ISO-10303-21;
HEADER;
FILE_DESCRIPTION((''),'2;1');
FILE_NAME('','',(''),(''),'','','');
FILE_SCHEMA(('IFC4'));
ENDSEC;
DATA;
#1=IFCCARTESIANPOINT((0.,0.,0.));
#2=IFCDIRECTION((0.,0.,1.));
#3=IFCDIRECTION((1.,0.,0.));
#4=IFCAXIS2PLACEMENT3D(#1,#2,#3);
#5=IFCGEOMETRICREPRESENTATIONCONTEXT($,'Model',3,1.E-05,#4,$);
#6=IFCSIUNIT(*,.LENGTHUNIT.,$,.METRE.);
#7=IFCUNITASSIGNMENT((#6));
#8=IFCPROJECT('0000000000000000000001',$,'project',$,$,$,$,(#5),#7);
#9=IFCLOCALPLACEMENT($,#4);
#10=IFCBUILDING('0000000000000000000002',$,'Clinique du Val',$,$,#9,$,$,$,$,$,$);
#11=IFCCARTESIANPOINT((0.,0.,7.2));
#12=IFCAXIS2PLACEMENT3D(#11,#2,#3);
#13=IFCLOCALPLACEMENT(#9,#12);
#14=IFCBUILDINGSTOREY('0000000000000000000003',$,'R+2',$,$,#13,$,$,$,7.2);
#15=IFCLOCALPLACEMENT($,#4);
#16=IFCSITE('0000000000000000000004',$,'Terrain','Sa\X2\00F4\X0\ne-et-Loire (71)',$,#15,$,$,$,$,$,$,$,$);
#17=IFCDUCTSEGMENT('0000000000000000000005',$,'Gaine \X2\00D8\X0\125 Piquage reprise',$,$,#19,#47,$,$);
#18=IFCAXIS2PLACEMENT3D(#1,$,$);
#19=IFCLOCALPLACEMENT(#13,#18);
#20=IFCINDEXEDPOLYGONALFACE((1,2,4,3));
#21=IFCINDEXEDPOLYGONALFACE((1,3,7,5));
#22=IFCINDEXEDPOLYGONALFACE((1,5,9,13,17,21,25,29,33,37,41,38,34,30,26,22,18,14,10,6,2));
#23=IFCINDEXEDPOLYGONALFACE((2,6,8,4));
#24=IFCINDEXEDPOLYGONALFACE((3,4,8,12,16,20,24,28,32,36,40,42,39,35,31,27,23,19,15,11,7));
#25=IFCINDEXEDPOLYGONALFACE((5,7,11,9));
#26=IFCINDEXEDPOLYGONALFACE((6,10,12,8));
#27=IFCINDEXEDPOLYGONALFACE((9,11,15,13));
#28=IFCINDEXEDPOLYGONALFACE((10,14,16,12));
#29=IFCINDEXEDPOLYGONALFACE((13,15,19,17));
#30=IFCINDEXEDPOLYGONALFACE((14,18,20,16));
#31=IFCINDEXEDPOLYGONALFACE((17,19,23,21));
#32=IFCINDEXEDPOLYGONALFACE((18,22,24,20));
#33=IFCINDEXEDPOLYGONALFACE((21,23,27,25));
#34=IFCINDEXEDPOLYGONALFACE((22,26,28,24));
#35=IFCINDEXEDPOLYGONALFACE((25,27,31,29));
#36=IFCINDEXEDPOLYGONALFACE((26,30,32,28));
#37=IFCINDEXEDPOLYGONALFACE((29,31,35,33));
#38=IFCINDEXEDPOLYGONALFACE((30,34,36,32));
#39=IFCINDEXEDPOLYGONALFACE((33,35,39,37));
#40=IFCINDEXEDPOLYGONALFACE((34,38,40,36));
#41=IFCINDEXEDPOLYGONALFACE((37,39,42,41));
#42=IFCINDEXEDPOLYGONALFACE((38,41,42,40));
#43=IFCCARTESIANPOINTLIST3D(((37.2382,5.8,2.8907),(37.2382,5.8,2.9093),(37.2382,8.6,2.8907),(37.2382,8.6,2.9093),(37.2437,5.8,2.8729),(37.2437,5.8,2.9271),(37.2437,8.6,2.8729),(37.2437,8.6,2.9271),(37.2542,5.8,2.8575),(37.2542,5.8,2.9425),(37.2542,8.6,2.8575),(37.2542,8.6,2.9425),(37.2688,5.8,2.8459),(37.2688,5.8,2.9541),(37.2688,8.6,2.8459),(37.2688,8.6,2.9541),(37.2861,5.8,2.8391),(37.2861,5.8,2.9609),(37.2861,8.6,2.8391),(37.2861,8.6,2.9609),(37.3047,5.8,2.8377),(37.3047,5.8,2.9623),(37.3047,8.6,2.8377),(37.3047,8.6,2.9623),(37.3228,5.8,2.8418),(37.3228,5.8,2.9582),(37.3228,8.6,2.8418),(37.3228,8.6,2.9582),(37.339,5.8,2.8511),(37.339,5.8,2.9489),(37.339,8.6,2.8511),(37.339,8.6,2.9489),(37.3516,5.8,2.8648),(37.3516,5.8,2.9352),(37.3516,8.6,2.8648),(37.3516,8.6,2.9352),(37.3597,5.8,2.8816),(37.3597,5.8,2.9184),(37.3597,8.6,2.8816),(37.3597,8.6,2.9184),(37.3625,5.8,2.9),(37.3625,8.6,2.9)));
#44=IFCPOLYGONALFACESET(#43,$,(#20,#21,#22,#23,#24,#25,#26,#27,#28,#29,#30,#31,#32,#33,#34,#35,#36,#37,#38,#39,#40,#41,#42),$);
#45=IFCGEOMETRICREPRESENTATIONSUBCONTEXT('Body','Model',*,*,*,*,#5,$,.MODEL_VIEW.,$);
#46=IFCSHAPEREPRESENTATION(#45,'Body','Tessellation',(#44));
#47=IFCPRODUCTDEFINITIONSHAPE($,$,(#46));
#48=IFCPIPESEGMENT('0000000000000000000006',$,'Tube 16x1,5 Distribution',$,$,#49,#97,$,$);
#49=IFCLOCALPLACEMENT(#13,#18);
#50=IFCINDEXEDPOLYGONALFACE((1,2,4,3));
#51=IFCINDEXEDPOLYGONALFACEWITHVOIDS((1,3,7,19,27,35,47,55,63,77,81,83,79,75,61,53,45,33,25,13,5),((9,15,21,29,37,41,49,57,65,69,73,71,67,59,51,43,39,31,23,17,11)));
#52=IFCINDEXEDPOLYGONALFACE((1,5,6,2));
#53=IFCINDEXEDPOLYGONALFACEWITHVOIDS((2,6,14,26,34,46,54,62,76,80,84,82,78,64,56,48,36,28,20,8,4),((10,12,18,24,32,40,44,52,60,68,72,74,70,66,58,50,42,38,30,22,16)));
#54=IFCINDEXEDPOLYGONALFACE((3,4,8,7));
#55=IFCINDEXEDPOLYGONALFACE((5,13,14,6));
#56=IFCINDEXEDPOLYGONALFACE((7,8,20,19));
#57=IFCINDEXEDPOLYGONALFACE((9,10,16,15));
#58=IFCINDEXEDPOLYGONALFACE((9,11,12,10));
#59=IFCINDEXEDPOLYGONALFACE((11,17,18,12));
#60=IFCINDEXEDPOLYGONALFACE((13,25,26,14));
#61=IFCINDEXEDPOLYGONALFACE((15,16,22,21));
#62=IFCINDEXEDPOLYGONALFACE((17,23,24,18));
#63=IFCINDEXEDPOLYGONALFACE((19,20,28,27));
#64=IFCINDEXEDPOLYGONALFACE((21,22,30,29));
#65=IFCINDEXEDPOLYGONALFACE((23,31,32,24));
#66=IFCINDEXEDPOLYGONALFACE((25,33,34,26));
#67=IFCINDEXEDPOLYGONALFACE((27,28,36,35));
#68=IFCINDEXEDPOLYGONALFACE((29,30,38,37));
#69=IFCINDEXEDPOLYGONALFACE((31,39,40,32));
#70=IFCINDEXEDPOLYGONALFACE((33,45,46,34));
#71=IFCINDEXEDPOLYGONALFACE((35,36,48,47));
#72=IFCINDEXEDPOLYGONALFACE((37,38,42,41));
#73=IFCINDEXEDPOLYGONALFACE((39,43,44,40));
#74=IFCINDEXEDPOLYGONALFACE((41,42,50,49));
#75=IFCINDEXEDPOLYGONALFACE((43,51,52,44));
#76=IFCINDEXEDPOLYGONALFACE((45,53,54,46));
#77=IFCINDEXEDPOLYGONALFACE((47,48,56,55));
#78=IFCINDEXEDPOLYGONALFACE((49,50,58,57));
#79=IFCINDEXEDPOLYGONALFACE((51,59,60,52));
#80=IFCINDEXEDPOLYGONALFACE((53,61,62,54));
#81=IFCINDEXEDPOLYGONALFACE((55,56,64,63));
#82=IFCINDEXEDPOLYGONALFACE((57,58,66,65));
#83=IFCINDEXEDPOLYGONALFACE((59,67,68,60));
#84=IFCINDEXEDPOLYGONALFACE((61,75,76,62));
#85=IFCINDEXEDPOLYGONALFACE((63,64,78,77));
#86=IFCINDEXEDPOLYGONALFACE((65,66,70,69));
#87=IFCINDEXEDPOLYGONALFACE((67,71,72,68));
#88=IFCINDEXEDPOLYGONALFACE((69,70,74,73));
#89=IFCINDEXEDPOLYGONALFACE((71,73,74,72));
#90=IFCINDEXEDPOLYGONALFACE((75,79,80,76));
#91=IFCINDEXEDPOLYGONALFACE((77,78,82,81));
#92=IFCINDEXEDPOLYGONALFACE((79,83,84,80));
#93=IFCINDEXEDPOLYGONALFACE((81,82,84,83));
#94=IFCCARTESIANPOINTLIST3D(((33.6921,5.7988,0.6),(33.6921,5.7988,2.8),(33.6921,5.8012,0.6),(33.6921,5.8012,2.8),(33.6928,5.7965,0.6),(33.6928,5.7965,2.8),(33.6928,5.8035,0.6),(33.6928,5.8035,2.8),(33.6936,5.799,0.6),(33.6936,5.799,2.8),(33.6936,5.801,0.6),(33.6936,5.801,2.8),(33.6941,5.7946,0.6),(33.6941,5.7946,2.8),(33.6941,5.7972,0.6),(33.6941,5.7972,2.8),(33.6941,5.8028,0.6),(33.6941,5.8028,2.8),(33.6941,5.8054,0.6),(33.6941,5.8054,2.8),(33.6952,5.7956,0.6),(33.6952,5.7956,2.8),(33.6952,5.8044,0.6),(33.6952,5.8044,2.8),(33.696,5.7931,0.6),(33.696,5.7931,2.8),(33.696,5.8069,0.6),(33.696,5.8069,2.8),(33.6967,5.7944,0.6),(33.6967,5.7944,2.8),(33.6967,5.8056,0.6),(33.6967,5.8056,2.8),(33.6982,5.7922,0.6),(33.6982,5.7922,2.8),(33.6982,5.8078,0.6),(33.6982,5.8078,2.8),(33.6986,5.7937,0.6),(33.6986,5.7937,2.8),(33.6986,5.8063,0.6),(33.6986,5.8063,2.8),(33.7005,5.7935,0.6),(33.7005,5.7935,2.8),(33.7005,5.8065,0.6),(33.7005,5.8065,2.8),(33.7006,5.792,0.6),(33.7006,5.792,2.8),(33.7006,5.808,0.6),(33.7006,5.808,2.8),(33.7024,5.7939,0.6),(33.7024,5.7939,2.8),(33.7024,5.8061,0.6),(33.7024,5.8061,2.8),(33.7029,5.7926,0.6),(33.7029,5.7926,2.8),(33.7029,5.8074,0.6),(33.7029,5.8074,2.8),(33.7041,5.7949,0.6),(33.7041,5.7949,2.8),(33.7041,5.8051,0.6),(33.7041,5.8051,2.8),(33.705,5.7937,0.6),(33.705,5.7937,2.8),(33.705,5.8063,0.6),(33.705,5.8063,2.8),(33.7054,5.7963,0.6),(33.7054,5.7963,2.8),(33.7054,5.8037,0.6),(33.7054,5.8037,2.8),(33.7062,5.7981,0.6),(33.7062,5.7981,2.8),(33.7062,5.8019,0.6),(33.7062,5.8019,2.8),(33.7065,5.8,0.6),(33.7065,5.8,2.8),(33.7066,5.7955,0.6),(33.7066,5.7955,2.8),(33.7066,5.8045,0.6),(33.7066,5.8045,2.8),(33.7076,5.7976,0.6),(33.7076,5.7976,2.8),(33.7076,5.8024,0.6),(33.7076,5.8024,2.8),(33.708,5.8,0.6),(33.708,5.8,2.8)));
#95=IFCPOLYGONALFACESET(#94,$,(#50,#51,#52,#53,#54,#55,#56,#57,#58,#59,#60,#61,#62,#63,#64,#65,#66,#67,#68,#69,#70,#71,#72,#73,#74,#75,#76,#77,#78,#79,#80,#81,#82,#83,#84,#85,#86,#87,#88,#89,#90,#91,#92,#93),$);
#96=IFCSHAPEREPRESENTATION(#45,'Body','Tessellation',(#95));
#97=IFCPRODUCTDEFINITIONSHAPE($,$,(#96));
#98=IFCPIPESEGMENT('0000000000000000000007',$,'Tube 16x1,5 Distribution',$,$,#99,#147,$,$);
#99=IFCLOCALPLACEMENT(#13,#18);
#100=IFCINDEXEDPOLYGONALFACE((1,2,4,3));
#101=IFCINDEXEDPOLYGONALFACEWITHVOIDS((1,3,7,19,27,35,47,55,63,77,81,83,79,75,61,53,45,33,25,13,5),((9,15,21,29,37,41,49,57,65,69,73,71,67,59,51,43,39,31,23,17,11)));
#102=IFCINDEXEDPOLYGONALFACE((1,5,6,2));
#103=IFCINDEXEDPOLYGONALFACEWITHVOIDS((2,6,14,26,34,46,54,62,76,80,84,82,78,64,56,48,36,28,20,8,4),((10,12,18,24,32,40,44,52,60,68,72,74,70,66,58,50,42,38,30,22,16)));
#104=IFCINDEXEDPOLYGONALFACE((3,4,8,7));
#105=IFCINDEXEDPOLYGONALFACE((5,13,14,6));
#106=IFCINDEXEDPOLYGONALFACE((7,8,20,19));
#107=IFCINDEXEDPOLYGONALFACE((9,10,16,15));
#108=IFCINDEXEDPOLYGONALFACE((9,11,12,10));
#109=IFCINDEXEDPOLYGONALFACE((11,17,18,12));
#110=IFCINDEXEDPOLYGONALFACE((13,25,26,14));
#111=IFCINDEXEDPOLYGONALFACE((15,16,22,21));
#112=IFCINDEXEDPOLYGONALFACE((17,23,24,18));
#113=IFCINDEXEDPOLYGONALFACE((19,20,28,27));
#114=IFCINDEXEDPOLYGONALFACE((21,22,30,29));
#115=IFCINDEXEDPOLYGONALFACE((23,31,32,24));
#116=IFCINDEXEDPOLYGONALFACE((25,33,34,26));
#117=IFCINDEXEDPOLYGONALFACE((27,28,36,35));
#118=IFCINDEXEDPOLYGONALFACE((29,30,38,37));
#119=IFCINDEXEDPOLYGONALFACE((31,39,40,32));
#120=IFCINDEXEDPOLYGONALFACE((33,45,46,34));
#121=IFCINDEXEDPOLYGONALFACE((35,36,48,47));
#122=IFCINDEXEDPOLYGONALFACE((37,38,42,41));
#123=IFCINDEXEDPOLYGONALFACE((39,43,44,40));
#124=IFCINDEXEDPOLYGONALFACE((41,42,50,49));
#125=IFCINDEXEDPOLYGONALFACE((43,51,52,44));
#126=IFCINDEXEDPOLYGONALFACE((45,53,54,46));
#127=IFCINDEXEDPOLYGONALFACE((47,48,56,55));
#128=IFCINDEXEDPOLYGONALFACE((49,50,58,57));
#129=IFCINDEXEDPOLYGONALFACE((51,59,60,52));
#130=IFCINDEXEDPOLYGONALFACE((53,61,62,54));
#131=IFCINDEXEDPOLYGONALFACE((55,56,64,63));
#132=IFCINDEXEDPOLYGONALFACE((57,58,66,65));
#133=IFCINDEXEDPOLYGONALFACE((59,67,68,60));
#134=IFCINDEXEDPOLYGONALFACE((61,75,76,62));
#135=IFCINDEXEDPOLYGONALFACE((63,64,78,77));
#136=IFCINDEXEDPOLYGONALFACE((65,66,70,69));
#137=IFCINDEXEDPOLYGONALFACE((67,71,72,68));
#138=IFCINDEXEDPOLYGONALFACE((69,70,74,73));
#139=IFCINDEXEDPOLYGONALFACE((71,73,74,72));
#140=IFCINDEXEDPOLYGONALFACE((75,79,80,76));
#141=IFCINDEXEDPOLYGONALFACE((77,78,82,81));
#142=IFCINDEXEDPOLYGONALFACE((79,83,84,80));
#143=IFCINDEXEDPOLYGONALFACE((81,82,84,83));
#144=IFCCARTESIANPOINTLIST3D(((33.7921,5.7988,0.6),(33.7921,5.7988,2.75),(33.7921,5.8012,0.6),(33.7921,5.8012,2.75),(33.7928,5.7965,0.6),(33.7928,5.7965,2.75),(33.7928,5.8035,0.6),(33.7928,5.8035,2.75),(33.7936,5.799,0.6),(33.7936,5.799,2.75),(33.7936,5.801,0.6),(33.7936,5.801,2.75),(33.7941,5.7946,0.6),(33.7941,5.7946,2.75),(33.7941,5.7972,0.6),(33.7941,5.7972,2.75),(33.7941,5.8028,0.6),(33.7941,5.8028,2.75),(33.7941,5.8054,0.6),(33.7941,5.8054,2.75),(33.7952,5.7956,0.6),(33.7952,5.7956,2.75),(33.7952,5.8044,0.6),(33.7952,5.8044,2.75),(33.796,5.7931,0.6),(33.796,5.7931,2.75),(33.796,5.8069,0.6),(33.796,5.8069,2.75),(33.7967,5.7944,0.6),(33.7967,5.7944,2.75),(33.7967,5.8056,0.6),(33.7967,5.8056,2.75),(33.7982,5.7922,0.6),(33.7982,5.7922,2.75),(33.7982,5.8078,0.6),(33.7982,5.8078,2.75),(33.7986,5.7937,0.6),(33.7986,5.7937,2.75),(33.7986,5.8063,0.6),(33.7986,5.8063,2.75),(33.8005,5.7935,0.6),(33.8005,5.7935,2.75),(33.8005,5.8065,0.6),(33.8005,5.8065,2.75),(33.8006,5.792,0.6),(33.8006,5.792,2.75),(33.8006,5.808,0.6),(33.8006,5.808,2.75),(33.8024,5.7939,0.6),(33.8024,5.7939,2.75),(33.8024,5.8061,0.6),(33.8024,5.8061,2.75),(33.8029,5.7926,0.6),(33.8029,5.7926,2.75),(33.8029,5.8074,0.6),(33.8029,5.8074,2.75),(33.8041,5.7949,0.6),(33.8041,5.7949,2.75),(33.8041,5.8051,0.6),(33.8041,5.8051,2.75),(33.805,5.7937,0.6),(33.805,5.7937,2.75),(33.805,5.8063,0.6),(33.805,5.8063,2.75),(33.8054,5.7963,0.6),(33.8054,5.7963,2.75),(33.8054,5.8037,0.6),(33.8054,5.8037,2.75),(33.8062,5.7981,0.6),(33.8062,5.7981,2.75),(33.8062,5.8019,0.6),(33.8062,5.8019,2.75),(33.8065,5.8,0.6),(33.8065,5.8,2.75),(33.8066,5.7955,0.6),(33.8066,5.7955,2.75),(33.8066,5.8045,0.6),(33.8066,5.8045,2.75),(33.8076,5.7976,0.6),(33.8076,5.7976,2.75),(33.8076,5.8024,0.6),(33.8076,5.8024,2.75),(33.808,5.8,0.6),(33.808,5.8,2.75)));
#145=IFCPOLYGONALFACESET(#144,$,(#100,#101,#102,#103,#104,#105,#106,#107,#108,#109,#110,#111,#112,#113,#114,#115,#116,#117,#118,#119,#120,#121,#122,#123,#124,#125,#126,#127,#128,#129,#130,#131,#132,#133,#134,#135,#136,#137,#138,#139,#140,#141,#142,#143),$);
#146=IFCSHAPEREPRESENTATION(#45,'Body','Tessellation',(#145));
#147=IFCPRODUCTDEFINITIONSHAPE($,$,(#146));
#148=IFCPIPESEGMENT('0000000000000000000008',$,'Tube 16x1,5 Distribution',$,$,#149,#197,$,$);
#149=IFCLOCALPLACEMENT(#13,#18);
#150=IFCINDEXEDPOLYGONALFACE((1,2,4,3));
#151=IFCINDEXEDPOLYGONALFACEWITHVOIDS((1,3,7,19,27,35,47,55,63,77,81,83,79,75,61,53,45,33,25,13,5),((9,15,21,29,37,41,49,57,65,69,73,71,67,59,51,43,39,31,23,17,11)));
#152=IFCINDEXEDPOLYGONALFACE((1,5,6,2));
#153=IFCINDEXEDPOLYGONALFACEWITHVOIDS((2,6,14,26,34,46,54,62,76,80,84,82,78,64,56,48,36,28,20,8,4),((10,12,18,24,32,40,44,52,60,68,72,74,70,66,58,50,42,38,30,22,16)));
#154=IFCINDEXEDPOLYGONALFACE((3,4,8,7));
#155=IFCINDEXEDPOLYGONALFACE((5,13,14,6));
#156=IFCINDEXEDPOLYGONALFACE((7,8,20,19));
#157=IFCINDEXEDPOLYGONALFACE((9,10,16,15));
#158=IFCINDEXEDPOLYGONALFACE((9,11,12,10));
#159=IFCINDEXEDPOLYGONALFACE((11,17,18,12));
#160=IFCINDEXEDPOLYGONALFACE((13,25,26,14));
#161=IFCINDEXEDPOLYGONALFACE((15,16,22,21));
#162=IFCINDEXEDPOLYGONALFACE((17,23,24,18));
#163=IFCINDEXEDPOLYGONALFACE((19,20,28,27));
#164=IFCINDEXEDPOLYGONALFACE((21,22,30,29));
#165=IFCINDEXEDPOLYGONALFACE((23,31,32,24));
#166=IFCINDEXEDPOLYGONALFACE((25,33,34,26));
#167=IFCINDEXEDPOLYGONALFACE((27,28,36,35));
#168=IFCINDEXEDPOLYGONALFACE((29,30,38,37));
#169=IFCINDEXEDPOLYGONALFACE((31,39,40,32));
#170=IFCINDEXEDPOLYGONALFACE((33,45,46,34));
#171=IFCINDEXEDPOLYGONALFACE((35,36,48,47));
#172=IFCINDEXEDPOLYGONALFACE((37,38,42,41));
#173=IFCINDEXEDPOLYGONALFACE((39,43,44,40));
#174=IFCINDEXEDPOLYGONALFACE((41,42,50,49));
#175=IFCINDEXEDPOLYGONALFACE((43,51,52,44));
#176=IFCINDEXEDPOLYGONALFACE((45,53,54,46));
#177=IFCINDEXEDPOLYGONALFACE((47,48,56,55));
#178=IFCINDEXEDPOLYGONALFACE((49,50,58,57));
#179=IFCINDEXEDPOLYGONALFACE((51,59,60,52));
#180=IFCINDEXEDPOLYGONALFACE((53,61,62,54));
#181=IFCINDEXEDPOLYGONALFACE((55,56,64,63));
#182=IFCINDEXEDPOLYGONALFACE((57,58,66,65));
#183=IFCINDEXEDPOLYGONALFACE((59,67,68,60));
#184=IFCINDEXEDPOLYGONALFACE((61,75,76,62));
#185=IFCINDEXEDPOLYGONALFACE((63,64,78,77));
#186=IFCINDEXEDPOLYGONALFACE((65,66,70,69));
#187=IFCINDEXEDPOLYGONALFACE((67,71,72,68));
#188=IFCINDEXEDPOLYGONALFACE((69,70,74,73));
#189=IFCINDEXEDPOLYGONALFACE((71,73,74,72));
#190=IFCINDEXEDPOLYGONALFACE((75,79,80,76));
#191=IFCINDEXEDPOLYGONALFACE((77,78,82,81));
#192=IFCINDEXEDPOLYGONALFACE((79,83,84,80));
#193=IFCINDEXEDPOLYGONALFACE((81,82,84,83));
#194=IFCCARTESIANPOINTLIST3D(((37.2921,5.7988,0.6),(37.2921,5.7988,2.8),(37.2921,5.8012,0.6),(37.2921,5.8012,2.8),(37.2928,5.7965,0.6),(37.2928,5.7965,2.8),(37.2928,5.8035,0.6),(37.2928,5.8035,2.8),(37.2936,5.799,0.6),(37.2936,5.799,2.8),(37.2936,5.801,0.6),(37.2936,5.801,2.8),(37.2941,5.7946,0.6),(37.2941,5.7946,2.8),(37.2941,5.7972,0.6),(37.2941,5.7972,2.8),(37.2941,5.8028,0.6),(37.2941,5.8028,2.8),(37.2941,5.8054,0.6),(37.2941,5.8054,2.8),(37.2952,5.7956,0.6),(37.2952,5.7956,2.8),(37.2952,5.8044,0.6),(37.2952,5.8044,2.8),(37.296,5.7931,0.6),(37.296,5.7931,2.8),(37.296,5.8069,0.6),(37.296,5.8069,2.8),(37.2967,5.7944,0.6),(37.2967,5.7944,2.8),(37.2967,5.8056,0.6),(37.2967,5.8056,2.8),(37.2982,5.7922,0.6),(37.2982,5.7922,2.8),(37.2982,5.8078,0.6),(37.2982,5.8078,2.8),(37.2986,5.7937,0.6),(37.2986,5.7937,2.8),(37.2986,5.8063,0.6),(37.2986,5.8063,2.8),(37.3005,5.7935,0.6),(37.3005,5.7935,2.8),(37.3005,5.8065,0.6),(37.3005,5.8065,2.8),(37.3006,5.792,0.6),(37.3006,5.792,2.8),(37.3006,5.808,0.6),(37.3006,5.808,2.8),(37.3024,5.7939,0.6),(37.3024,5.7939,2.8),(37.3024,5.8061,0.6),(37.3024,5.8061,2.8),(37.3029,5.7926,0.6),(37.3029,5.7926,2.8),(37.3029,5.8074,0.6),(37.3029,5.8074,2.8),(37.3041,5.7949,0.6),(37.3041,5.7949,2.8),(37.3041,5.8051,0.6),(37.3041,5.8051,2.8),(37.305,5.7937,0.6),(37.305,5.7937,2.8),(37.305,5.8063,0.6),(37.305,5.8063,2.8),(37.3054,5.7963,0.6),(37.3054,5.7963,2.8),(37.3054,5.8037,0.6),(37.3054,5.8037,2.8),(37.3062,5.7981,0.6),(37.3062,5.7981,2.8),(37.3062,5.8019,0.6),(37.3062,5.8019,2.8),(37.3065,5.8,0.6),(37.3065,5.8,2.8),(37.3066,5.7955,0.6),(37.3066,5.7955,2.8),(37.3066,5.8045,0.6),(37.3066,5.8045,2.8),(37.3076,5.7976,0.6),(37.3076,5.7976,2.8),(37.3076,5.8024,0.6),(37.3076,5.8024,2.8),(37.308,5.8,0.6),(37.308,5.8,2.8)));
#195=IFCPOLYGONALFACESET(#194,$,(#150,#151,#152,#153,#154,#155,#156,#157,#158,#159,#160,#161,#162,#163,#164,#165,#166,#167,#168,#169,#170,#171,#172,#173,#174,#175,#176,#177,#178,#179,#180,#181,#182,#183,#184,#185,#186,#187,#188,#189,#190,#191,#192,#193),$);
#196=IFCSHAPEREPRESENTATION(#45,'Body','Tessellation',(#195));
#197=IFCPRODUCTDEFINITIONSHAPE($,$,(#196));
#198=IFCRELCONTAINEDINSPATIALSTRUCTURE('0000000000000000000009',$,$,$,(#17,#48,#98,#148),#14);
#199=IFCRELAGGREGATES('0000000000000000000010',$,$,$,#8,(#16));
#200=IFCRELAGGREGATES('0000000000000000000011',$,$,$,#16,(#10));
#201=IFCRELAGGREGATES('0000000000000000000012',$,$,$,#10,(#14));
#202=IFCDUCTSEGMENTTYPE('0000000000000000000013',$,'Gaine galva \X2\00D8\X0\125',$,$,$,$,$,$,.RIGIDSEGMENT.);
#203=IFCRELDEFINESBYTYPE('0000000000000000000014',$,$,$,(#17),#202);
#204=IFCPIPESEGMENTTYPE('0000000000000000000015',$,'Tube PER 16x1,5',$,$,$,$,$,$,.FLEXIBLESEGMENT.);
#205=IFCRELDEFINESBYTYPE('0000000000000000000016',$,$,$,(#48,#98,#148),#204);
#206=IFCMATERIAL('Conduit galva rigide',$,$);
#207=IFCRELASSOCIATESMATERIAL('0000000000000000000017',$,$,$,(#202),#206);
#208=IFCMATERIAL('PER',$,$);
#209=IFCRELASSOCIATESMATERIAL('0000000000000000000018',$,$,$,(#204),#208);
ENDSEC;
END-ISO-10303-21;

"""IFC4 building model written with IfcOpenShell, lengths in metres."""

from ifc_helpers import new_model, si_unit, frame, origin_with_axes, place, context, subcontext, project, spatial, circle, hollow_circle, extrude, material, type_object, element, save


model = new_model("IFC4")

# Units and contexts
model_context = context("Model", 3, precision=1e-05, world=origin_with_axes())
body_context = subcontext(model_context, "Body", "Model", "MODEL_VIEW")
ifc_project = project(units=[si_unit("LENGTHUNIT", "METRE")], contexts=[model_context])

# Site, building, storey
site_placement = place(None, origin_with_axes())
site = spatial("IfcSite", under=ifc_project, at=site_placement, Name="Terrain", Description="Saône-et-Loire (71)")
building_placement = place(None, origin_with_axes())
building = spatial("IfcBuilding", under=site, at=building_placement, Name="Clinique du Val")
storey_placement = place(building_placement, frame((0.0, 0.0, 7.2), z_axis=(0.0, 0.0, 1.0), x_axis=(1.0, 0.0, 0.0)))
storey = spatial("IfcBuildingStorey", under=building, at=storey_placement, Name="R+2", Elevation=7.2)

# Duct segment
ifc_material_1 = material(Name="Conduit galva rigide")
duct_segment_type = type_object("IfcDuctSegmentType", Name="Gaine galva Ø125", PredefinedType="RIGIDSEGMENT", material=ifc_material_1)
duct_segment_1_placement = place(storey_placement, frame((37.3, 5.8, 2.9), z_axis=(0.0, 1.0, 0.0), x_axis=(1.0, 0.0, 0.0)))
element("IfcDuctSegment", 1, at=duct_segment_1_placement, inside=storey, type_object=duct_segment_type, Name="Gaine Ø125 Piquage reprise", context=body_context, shape_type="SweptSolid", body=[
    extrude(circle(Radius=0.0625), origin_with_axes(), (0.0, 0.0, 1.0), 2.8),
])

# Pipe segments
ifc_material_2 = material(Name="PER")
pipe_segment_type_1 = type_object("IfcPipeSegmentType", Name="Tube PER 16x1,5", PredefinedType="FLEXIBLESEGMENT", material=ifc_material_2)
pipe_segment_1_placement = place(storey_placement, frame((33.7, 5.8, 2.8), z_axis=(0.0, 0.0, -1.0), x_axis=(1.0, 0.0, 0.0)))
element("IfcPipeSegment", 2, at=pipe_segment_1_placement, inside=storey, type_object=pipe_segment_type_1, Name="Tube 16x1,5 Distribution", context=body_context, shape_type="SweptSolid", body=[
    extrude(hollow_circle(Radius=0.008, WallThickness=0.0015), origin_with_axes(), (0.0, 0.0, 1.0), 2.2),
])
pipe_segment_2_placement = place(storey_placement, frame((33.8, 5.8, 2.75), z_axis=(0.0, 0.0, -1.0), x_axis=(1.0, 0.0, 0.0)))
element("IfcPipeSegment", 3, at=pipe_segment_2_placement, inside=storey, type_object=pipe_segment_type_1, Name="Tube 16x1,5 Distribution", context=body_context, shape_type="SweptSolid", body=[
    extrude(hollow_circle(Radius=0.008, WallThickness=0.0015), origin_with_axes(), (0.0, 0.0, 1.0), 2.15),
])
pipe_segment_3_placement = place(storey_placement, frame((37.3, 5.8, 2.8), z_axis=(0.0, 0.0, -1.0), x_axis=(1.0, 0.0, 0.0)))
element("IfcPipeSegment", 4, at=pipe_segment_3_placement, inside=storey, type_object=pipe_segment_type_1, Name="Tube 16x1,5 Distribution", context=body_context, shape_type="SweptSolid", body=[
    extrude(hollow_circle(Radius=0.008, WallThickness=0.0015), origin_with_axes(), (0.0, 0.0, 1.0), 2.2),
])

save(model, "model.ifc")
